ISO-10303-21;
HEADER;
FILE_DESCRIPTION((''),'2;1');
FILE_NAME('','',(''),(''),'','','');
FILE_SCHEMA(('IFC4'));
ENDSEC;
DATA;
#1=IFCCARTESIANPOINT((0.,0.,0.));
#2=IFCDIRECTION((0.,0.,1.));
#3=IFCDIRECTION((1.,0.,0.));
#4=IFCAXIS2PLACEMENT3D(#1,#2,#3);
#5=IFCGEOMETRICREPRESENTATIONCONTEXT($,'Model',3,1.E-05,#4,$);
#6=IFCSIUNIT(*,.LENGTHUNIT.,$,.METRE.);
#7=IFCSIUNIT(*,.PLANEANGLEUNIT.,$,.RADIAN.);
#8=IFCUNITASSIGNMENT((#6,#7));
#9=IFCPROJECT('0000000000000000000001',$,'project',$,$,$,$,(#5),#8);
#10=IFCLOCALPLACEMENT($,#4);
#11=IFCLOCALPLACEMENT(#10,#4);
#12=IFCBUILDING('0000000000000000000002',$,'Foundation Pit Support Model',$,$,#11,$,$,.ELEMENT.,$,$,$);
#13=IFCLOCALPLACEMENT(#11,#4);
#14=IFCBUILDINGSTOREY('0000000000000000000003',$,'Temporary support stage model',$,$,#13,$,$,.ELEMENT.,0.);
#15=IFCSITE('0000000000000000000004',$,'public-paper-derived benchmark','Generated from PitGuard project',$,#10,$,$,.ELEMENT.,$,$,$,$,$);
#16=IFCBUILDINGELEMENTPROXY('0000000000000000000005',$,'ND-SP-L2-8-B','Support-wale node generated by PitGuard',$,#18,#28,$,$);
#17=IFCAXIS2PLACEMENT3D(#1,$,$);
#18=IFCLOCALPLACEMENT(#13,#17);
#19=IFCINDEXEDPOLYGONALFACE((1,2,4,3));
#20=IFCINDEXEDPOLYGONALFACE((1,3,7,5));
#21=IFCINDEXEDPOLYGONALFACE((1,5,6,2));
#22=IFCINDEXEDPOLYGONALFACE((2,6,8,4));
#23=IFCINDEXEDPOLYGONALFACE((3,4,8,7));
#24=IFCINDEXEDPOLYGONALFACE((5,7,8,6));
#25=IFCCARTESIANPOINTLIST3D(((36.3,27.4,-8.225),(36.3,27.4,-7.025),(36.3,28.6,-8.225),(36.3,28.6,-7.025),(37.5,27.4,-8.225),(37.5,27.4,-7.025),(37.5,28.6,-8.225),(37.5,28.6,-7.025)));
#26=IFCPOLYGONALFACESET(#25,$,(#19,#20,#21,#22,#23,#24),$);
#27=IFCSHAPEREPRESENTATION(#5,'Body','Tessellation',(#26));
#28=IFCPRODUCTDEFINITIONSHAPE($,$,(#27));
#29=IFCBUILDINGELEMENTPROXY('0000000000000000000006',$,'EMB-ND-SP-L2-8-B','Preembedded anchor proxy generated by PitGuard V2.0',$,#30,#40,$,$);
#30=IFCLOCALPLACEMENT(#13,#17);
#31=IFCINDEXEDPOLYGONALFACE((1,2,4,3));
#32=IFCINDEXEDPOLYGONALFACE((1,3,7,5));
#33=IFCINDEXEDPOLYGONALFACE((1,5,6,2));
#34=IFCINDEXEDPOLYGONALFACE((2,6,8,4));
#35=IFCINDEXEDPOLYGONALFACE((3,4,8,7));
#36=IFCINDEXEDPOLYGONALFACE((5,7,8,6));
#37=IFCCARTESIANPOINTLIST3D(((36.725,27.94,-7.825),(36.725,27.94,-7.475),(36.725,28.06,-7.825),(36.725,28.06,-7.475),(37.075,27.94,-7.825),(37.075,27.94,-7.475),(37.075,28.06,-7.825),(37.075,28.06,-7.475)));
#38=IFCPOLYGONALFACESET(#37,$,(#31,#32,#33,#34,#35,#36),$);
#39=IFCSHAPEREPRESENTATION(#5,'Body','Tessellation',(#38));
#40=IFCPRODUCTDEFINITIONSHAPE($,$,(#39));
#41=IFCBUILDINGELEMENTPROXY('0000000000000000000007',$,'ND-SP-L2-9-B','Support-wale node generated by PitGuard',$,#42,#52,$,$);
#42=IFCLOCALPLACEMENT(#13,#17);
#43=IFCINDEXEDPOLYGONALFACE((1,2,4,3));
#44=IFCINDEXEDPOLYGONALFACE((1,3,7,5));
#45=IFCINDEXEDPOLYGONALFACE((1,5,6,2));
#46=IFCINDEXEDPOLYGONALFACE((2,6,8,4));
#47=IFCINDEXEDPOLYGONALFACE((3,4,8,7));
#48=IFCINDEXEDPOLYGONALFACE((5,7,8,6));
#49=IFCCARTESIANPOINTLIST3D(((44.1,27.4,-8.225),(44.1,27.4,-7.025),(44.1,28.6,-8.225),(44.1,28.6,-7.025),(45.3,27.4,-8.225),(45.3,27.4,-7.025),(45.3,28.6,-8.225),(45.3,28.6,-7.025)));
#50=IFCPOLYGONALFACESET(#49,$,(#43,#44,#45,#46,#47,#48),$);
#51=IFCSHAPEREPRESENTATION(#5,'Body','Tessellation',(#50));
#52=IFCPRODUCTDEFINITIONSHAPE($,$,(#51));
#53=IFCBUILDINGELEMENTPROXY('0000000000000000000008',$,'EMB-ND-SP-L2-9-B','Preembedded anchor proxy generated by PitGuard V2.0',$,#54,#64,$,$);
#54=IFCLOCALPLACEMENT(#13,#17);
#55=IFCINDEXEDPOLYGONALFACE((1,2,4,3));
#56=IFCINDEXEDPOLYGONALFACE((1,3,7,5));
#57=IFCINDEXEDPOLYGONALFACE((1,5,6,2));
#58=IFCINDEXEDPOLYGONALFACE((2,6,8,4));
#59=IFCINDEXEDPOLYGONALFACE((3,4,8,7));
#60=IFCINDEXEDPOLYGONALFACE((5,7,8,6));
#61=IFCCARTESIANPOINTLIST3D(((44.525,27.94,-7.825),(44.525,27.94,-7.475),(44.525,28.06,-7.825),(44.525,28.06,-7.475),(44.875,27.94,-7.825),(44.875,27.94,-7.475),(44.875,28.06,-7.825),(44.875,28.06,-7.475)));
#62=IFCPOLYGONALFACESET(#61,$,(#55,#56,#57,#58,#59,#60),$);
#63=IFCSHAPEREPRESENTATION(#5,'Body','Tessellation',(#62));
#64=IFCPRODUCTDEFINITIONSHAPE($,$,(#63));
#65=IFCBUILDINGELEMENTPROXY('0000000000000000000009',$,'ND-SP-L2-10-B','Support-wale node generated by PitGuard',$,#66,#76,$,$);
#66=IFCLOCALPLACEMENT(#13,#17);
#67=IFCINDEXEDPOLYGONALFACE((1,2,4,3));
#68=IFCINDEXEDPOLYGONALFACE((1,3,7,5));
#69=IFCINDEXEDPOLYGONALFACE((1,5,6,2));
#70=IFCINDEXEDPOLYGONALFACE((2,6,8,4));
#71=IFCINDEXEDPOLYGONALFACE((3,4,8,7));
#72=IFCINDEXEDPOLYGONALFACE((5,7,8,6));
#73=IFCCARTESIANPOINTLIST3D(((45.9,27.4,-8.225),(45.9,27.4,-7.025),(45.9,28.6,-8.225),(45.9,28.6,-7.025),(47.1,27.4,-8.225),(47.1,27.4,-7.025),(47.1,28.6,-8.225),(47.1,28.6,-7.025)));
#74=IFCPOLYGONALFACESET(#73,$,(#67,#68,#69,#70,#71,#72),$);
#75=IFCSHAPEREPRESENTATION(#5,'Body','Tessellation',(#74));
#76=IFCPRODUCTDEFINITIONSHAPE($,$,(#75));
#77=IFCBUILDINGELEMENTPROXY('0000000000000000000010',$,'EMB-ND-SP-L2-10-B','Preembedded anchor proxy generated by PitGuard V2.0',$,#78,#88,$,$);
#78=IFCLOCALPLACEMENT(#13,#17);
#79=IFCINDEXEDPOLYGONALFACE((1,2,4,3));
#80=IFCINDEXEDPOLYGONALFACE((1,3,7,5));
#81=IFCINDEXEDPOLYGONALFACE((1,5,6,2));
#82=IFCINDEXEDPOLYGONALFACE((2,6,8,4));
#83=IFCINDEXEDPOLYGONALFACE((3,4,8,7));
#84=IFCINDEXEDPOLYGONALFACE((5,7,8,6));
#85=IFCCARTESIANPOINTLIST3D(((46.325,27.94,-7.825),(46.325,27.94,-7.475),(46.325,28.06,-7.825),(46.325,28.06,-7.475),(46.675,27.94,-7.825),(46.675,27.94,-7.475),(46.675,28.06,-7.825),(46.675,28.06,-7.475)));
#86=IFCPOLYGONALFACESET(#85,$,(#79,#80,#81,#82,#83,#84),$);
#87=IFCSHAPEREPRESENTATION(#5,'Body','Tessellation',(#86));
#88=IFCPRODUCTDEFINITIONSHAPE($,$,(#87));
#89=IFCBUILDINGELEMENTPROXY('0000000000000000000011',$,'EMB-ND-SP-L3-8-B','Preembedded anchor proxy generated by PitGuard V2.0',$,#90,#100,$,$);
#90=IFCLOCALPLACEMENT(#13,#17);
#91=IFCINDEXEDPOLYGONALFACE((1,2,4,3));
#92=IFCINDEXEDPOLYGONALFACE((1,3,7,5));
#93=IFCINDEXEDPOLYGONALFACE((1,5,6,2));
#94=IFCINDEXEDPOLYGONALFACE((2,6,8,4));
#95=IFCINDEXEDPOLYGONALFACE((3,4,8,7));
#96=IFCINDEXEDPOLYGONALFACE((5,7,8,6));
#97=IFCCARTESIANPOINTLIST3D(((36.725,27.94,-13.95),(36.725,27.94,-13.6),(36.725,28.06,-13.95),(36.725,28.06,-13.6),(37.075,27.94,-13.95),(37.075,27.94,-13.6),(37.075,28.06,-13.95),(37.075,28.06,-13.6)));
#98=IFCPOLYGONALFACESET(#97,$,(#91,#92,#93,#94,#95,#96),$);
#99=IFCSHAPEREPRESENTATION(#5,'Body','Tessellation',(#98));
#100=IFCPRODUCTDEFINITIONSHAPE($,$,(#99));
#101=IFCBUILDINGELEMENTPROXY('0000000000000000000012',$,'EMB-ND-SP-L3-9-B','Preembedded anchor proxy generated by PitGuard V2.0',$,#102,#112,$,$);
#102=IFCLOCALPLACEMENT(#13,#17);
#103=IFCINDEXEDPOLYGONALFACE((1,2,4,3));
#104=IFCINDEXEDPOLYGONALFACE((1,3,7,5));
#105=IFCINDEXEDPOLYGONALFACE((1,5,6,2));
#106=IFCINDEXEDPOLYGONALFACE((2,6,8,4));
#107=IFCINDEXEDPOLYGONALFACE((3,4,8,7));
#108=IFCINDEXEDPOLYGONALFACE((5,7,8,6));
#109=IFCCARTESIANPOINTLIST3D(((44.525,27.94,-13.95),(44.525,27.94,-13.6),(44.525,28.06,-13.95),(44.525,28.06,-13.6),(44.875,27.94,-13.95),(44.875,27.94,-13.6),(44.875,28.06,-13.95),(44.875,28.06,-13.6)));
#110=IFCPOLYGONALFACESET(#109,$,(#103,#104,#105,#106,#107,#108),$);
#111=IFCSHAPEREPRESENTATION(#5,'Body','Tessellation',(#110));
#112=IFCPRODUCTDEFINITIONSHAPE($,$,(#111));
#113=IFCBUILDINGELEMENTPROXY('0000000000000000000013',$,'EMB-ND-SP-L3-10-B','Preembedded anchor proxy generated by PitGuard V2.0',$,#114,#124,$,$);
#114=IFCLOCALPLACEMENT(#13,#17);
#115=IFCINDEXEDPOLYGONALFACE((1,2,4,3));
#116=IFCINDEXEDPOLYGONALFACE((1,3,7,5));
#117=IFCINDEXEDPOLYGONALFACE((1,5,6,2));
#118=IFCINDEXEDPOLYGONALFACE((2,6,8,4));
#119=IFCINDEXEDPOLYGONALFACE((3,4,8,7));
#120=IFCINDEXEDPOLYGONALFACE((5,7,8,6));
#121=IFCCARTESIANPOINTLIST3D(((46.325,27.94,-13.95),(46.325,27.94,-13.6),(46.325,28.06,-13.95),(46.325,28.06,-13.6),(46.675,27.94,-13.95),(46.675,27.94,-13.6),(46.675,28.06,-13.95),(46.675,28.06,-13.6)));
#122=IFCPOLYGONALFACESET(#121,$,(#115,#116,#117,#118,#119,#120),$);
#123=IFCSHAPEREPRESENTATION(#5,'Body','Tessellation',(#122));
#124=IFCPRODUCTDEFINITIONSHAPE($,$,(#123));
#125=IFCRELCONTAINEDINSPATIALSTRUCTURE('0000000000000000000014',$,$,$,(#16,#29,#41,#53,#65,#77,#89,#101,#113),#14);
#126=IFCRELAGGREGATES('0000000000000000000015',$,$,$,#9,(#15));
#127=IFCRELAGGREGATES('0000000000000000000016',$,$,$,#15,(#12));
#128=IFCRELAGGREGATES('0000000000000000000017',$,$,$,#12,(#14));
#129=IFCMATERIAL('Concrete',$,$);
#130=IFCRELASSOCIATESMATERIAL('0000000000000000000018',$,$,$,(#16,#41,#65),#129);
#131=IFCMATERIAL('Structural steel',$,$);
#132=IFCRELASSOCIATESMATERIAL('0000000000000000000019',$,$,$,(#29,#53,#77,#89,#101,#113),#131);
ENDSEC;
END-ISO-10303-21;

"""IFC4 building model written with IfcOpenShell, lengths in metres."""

from ifc_helpers import new_model, si_unit, frame, origin_with_axes, origin_2d, place, context, project, spatial, rectangle, extrude, material, element, save


model = new_model("IFC4")

# Units and contexts
model_context = context("Model", 3, precision=1e-05, world=origin_with_axes())
ifc_project = project(units=[si_unit("LENGTHUNIT", "METRE"), si_unit("PLANEANGLEUNIT", "RADIAN")], contexts=[model_context])

# Site, building, storey
site_placement = place(None, origin_with_axes())
site = spatial("IfcSite", under=ifc_project, at=site_placement, Name="public-paper-derived benchmark", Description="Generated from PitGuard project", CompositionType="ELEMENT")
building_placement = place(site_placement, origin_with_axes())
building = spatial("IfcBuilding", under=site, at=building_placement, Name="Foundation Pit Support Model", CompositionType="ELEMENT")
storey_placement = place(building_placement, origin_with_axes())
storey = spatial("IfcBuildingStorey", under=building, at=storey_placement, Name="Temporary support stage model", CompositionType="ELEMENT", Elevation=0.0)

# Shared definitions
ifc_material_1 = material(Name="Concrete")

# Shared definitions
ifc_material_2 = material(Name="Structural steel")

# Building element proxies
proxy_1_placement = place(storey_placement, frame((36.9, 28.0, -8.225), z_axis=(0.0, 0.0, 1.0), x_axis=(1.0, 0.0, 0.0)))
element("IfcBuildingElementProxy", 1, at=proxy_1_placement, inside=storey, material=ifc_material_1, Name="ND-SP-L2-8-B", Description="Support-wale node generated by PitGuard", context=model_context, shape_type="SweptSolid", body=[
    extrude(rectangle(XDim=1.2, YDim=1.2, at=origin_2d()), origin_with_axes(), (0.0, 0.0, 1.0), 1.2),
])
proxy_2_placement = place(storey_placement, frame((36.9, 28.0, -7.825), z_axis=(0.0, 0.0, 1.0), x_axis=(1.0, 0.0, 0.0)))
element("IfcBuildingElementProxy", 2, at=proxy_2_placement, inside=storey, material=ifc_material_2, Name="EMB-ND-SP-L2-8-B", Description="Preembedded anchor proxy generated by PitGuard V2.0", context=model_context, shape_type="SweptSolid", body=[
    extrude(rectangle(XDim=0.35, YDim=0.12, at=origin_2d()), origin_with_axes(), (0.0, 0.0, 1.0), 0.35),
])
proxy_3_placement = place(storey_placement, frame((44.7, 28.0, -8.225), z_axis=(0.0, 0.0, 1.0), x_axis=(1.0, 0.0, 0.0)))
element("IfcBuildingElementProxy", 3, at=proxy_3_placement, inside=storey, material=ifc_material_1, Name="ND-SP-L2-9-B", Description="Support-wale node generated by PitGuard", context=model_context, shape_type="SweptSolid", body=[
    extrude(rectangle(XDim=1.2, YDim=1.2, at=origin_2d()), origin_with_axes(), (0.0, 0.0, 1.0), 1.2),
])
proxy_4_placement = place(storey_placement, frame((44.7, 28.0, -7.825), z_axis=(0.0, 0.0, 1.0), x_axis=(1.0, 0.0, 0.0)))
element("IfcBuildingElementProxy", 4, at=proxy_4_placement, inside=storey, material=ifc_material_2, Name="EMB-ND-SP-L2-9-B", Description="Preembedded anchor proxy generated by PitGuard V2.0", context=model_context, shape_type="SweptSolid", body=[
    extrude(rectangle(XDim=0.35, YDim=0.12, at=origin_2d()), origin_with_axes(), (0.0, 0.0, 1.0), 0.35),
])
proxy_5_placement = place(storey_placement, frame((46.5, 28.0, -8.225), z_axis=(0.0, 0.0, 1.0), x_axis=(1.0, 0.0, 0.0)))
element("IfcBuildingElementProxy", 5, at=proxy_5_placement, inside=storey, material=ifc_material_1, Name="ND-SP-L2-10-B", Description="Support-wale node generated by PitGuard", context=model_context, shape_type="SweptSolid", body=[
    extrude(rectangle(XDim=1.2, YDim=1.2, at=origin_2d()), origin_with_axes(), (0.0, 0.0, 1.0), 1.2),
])
for number, where, z_axis, x_axis, name in (
    (6, (46.5, 28.0, -7.825), (0.0, 0.0, 1.0), (1.0, 0.0, 0.0), "EMB-ND-SP-L2-10-B"),
    (7, (36.9, 28.0, -13.95), (0.0, 0.0, 1.0), (1.0, 0.0, 0.0), "EMB-ND-SP-L3-8-B"),
    (8, (44.7, 28.0, -13.95), (0.0, 0.0, 1.0), (1.0, 0.0, 0.0), "EMB-ND-SP-L3-9-B"),
    (9, (46.5, 28.0, -13.95), (0.0, 0.0, 1.0), (1.0, 0.0, 0.0), "EMB-ND-SP-L3-10-B"),
):
    element("IfcBuildingElementProxy", number, at=place(storey_placement, frame(where, z_axis=z_axis, x_axis=x_axis)), inside=storey, material=ifc_material_2, Name=name, Description="Preembedded anchor proxy generated by PitGuard V2.0", context=model_context, shape_type="SweptSolid", body=[
        extrude(rectangle(XDim=0.35, YDim=0.12, at=origin_2d()), origin_with_axes(), (0.0, 0.0, 1.0), 0.35),
    ])

save(model, "model.ifc")
